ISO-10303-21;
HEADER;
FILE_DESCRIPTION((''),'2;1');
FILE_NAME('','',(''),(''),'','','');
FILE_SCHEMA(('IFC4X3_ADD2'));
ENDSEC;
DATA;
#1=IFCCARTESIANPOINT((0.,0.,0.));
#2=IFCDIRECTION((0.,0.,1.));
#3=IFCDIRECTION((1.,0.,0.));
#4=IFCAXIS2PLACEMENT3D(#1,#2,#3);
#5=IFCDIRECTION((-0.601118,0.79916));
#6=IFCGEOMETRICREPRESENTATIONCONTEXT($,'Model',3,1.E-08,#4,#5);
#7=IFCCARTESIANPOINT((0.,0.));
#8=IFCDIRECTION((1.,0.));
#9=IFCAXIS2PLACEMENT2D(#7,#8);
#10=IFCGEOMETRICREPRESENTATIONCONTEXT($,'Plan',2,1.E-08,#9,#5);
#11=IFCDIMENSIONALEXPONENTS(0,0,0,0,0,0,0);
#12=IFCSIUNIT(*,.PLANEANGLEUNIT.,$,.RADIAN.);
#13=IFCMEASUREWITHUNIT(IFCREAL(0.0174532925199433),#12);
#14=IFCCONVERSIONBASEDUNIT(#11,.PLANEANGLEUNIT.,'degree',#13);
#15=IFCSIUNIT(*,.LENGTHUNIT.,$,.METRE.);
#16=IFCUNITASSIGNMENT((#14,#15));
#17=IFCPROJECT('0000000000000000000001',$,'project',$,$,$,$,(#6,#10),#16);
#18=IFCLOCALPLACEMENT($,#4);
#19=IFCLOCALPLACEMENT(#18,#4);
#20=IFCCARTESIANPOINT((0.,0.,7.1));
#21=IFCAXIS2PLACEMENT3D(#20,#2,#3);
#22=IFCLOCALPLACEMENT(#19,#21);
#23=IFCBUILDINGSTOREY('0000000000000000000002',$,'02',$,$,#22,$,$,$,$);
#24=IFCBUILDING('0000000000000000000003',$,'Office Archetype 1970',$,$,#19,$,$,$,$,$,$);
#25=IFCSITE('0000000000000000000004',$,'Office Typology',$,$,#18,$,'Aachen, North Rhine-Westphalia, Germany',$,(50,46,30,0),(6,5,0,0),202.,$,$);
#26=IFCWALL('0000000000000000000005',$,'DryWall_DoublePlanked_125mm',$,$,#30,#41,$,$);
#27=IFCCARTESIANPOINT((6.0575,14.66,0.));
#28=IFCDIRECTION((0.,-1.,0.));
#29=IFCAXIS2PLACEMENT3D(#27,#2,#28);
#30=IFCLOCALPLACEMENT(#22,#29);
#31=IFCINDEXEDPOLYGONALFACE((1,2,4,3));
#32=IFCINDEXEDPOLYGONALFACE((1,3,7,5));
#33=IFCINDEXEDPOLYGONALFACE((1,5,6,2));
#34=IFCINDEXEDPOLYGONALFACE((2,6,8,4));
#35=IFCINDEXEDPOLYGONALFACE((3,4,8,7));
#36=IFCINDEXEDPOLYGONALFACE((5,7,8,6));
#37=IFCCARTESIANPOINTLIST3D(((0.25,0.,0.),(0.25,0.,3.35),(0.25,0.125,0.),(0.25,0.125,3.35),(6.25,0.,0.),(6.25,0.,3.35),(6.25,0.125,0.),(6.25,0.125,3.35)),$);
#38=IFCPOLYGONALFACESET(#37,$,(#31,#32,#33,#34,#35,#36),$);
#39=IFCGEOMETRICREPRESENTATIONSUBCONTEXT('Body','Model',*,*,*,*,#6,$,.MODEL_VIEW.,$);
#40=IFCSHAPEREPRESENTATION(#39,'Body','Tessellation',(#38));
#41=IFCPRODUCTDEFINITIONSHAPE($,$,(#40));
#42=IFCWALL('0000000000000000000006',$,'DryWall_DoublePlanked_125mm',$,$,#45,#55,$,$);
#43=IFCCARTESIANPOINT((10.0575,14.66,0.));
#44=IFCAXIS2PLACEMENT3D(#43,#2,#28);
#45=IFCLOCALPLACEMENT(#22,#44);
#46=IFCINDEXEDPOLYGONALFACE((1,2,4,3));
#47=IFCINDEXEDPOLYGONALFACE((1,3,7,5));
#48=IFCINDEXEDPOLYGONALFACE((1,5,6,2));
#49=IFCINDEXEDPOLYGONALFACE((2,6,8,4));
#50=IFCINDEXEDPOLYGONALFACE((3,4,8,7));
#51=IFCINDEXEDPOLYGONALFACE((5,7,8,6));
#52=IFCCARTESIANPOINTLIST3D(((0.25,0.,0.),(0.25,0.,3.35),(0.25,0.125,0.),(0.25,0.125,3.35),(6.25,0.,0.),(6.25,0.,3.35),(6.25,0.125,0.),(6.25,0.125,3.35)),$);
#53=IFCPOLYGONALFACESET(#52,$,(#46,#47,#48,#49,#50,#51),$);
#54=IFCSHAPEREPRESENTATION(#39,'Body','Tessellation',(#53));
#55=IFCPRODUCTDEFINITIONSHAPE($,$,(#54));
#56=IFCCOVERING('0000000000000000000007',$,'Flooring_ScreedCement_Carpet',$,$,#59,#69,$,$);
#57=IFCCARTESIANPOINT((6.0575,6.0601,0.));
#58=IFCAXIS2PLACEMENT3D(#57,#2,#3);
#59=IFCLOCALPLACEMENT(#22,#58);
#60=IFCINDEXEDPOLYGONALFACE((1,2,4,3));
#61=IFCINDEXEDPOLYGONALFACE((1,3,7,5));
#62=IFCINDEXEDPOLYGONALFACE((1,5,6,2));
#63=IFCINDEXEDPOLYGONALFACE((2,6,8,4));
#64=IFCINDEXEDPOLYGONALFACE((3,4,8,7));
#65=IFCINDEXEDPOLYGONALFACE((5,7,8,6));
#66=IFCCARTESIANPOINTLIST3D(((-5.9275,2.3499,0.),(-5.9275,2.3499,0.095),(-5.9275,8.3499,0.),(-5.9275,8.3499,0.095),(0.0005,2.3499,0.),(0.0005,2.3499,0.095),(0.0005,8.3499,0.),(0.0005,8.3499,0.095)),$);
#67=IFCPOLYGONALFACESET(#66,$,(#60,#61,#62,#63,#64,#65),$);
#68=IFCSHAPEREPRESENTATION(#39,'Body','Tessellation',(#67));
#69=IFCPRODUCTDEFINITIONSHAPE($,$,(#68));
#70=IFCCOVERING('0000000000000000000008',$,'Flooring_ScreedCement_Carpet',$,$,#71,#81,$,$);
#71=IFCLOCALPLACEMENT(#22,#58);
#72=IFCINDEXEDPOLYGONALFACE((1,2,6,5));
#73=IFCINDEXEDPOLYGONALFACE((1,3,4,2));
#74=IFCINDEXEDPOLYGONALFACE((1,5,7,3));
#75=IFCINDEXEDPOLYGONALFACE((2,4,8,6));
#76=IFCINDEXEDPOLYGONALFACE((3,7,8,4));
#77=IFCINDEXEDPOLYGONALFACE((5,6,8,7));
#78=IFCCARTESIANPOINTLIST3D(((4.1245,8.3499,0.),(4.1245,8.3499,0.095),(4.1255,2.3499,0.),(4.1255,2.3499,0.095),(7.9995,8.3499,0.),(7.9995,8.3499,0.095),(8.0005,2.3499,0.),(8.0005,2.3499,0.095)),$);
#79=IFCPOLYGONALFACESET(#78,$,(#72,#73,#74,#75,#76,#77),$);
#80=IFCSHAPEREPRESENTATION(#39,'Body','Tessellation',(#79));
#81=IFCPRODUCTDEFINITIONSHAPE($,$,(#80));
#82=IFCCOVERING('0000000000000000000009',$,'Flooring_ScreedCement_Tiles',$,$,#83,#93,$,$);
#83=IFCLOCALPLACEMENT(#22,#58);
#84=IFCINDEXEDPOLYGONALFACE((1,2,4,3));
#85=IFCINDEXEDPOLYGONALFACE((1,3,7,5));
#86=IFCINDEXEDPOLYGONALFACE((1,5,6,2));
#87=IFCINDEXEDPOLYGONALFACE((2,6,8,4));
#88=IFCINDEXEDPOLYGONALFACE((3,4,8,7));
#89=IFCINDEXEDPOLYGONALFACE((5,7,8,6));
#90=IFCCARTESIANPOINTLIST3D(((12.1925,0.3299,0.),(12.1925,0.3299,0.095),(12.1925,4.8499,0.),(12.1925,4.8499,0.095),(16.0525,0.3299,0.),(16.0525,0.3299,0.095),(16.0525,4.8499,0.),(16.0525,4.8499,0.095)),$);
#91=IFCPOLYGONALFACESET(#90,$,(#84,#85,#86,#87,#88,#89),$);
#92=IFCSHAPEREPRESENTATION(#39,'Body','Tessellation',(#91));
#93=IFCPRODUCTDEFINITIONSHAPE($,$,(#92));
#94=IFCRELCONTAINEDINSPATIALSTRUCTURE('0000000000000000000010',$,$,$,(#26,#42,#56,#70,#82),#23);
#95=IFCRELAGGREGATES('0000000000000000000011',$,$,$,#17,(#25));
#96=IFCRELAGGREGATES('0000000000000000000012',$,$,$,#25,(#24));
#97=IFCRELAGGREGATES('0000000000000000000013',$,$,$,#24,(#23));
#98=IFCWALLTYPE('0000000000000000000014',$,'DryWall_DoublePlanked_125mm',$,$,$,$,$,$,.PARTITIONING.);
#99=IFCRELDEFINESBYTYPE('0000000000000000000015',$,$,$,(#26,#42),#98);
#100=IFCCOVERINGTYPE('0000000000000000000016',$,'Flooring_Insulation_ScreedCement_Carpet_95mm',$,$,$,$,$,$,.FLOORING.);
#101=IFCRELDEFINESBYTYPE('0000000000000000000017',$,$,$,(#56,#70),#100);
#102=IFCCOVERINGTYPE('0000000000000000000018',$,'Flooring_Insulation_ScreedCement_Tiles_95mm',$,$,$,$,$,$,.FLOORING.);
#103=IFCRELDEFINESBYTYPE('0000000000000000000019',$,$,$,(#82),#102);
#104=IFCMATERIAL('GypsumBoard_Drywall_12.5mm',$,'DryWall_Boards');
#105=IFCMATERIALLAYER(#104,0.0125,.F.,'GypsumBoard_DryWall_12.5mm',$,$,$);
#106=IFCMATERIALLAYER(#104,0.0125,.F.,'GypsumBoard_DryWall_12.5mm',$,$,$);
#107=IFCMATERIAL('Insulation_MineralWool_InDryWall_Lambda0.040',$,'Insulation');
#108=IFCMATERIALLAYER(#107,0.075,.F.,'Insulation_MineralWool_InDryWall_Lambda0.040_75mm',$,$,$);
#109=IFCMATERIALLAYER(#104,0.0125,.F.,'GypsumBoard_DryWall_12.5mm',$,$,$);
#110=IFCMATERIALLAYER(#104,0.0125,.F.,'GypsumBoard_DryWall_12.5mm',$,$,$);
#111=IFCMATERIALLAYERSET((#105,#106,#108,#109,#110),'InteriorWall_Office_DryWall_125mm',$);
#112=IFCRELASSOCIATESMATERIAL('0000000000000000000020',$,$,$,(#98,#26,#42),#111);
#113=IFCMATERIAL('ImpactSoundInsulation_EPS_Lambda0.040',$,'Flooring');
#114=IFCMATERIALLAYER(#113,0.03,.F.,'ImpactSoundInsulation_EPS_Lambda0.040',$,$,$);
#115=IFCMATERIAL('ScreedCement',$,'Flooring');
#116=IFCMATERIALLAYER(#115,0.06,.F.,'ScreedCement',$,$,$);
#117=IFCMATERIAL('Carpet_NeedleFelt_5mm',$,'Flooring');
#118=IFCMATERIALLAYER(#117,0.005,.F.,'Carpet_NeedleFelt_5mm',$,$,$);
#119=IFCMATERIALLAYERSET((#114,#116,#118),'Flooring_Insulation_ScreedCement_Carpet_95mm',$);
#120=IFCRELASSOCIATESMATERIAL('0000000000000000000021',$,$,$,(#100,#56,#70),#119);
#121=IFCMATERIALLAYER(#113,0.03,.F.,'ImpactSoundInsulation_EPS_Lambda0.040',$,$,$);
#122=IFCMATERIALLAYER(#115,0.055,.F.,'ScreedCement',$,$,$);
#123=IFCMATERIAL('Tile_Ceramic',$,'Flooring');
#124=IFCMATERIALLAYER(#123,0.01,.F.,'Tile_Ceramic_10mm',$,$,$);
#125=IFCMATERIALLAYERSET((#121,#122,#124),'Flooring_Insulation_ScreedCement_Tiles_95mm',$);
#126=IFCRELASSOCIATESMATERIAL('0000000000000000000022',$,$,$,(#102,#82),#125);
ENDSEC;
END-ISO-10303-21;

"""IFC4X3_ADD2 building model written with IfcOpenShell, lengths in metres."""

from ifc_helpers import new_model, entity, si_unit, converted_unit, direction, frame, origin_with_axes, origin_2d_with_axis, place, context, subcontext, project, spatial, line, indexed_curve, outline, extrude, material, layer, layer_set, layer_usage, type_object, element, save


model = new_model("IFC4X3_ADD2")

# Units and contexts
model_context = context("Model", 3, precision=1e-08, world=origin_with_axes(), true_north=direction((-0.601118, 0.79916)))
plan_context = context("Plan", 2, precision=1e-08, world=origin_2d_with_axis(), true_north=direction((-0.601118, 0.79916)))
body_context = subcontext(model_context, "Body", "Model", "MODEL_VIEW")
ifc_project = project(units=[converted_unit("PLANEANGLEUNIT", "degree", entity("IfcReal", 0.0174532925199433), si_unit("PLANEANGLEUNIT", "RADIAN"), dimensions=[0, 0, 0, 0, 0, 0, 0]), si_unit("LENGTHUNIT", "METRE")], contexts=[model_context, plan_context])

# Site, building, storey
site_placement = place(None, origin_with_axes())
site = spatial("IfcSite", under=ifc_project, at=site_placement, Name="Office Typology", LongName="Aachen, North Rhine-Westphalia, Germany", RefLatitude=(50, 46, 30, 0), RefLongitude=(6, 5, 0, 0), RefElevation=202.0)
building_placement = place(site_placement, origin_with_axes())
building = spatial("IfcBuilding", under=site, at=building_placement, Name="Office Archetype 1970")
storey_placement = place(building_placement, frame((0.0, 0.0, 7.1), z_axis=(0.0, 0.0, 1.0), x_axis=(1.0, 0.0, 0.0)))
storey = spatial("IfcBuildingStorey", under=building, at=storey_placement, Name="02")

# Walls
ifc_material_1 = material(Name="GypsumBoard_Drywall_12.5mm", Category="DryWall_Boards")
ifc_layer_1 = layer(ifc_material_1, 0.0125, ventilated=False, Name="GypsumBoard_DryWall_12.5mm")
ifc_layer_2 = layer(ifc_material_1, 0.0125, ventilated=False, Name="GypsumBoard_DryWall_12.5mm")
ifc_material_2 = material(Name="Insulation_MineralWool_InDryWall_Lambda0.040", Category="Insulation")
ifc_layer_3 = layer(ifc_material_2, 0.075, ventilated=False, Name="Insulation_MineralWool_InDryWall_Lambda0.040_75mm")
ifc_layer_4 = layer(ifc_material_1, 0.0125, ventilated=False, Name="GypsumBoard_DryWall_12.5mm")
ifc_layer_5 = layer(ifc_material_1, 0.0125, ventilated=False, Name="GypsumBoard_DryWall_12.5mm")
ifc_layer_set_1 = layer_set([ifc_layer_1, ifc_layer_2, ifc_layer_3, ifc_layer_4, ifc_layer_5], Name="InteriorWall_Office_DryWall_125mm")
wall_type_1 = type_object("IfcWallType", Name="DryWall_DoublePlanked_125mm", PredefinedType="PARTITIONING", material=ifc_layer_set_1)
ifc_layer_usage_1 = layer_usage(ifc_layer_set_1, "AXIS2", "POSITIVE", 0.0)
wall_1_placement = place(storey_placement, frame((6.0575, 14.66, 0.0), z_axis=(0.0, 0.0, 1.0), x_axis=(0.0, -1.0, 0.0)))
element("IfcWall", 1, at=wall_1_placement, inside=storey, type_object=wall_type_1, material=ifc_layer_usage_1, Name="DryWall_DoublePlanked_125mm", context=body_context, shape_type="SweptSolid", body=[
    extrude(outline(indexed_curve([(0.25, 0.0), (0.25, 0.125), (6.25, 0.125), (6.25, 0.0)], segments=[line(1, 2, 3, 4, 1)])), origin_with_axes(), (0.0, 0.0, 1.0), 3.35),
])
ifc_layer_usage_2 = layer_usage(ifc_layer_set_1, "AXIS2", "POSITIVE", 0.0)
wall_2_placement = place(storey_placement, frame((10.0575, 14.66, 0.0), z_axis=(0.0, 0.0, 1.0), x_axis=(0.0, -1.0, 0.0)))
element("IfcWall", 2, at=wall_2_placement, inside=storey, type_object=wall_type_1, material=ifc_layer_usage_2, Name="DryWall_DoublePlanked_125mm", context=body_context, shape_type="SweptSolid", body=[
    extrude(outline(indexed_curve([(0.25, 0.0), (0.25, 0.125), (6.25, 0.125), (6.25, 0.0)], segments=[line(1, 2, 3, 4, 1)])), origin_with_axes(), (0.0, 0.0, 1.0), 3.35),
])

# Coverings
ifc_material_3 = material(Name="ImpactSoundInsulation_EPS_Lambda0.040", Category="Flooring")
ifc_layer_6 = layer(ifc_material_3, 0.03, ventilated=False, Name="ImpactSoundInsulation_EPS_Lambda0.040")
ifc_material_4 = material(Name="ScreedCement", Category="Flooring")
ifc_layer_7 = layer(ifc_material_4, 0.06, ventilated=False, Name="ScreedCement")
ifc_material_5 = material(Name="Carpet_NeedleFelt_5mm", Category="Flooring")
ifc_layer_8 = layer(ifc_material_5, 0.005, ventilated=False, Name="Carpet_NeedleFelt_5mm")
ifc_layer_set_2 = layer_set([ifc_layer_6, ifc_layer_7, ifc_layer_8], Name="Flooring_Insulation_ScreedCement_Carpet_95mm")
ifc_layer_usage_3 = layer_usage(ifc_layer_set_2, "AXIS3", "POSITIVE", 0.0)
covering_type_1 = type_object("IfcCoveringType", Name="Flooring_Insulation_ScreedCement_Carpet_95mm", PredefinedType="FLOORING", material=ifc_layer_set_2)
covering_1_placement = place(storey_placement, frame((6.0575, 6.0601, 0.0), z_axis=(0.0, 0.0, 1.0), x_axis=(1.0, 0.0, 0.0)))
element("IfcCovering", 3, at=covering_1_placement, inside=storey, type_object=covering_type_1, material=ifc_layer_usage_3, Name="Flooring_ScreedCement_Carpet", context=body_context, shape_type="SweptSolid", body=[
    extrude(outline(indexed_curve([(-5.9275, 2.3499), (-5.9275, 8.3499), (0.0005, 8.3499), (0.0005, 2.3499)], segments=[line(1, 2, 3, 4, 1)])), origin_with_axes(), (0.0, 0.0, 1.0), 0.095),
])
ifc_layer_usage_4 = layer_usage(ifc_layer_set_2, "AXIS3", "POSITIVE", 0.0)
covering_2_placement = place(storey_placement, frame((6.0575, 6.0601, 0.0), z_axis=(0.0, 0.0, 1.0), x_axis=(1.0, 0.0, 0.0)))
element("IfcCovering", 4, at=covering_2_placement, inside=storey, type_object=covering_type_1, material=ifc_layer_usage_4, Name="Flooring_ScreedCement_Carpet", context=body_context, shape_type="SweptSolid", body=[
    extrude(outline(indexed_curve([(4.1255, 2.3499), (4.1245, 8.3499), (7.9995, 8.3499), (8.0005, 2.3499)], segments=[line(1, 2, 3, 4, 1)])), origin_with_axes(), (0.0, 0.0, 1.0), 0.095),
])
ifc_layer_9 = layer(ifc_material_3, 0.03, ventilated=False, Name="ImpactSoundInsulation_EPS_Lambda0.040")
ifc_layer_10 = layer(ifc_material_4, 0.055, ventilated=False, Name="ScreedCement")
ifc_material_6 = material(Name="Tile_Ceramic", Category="Flooring")
ifc_layer_11 = layer(ifc_material_6, 0.01, ventilated=False, Name="Tile_Ceramic_10mm")
ifc_layer_set_3 = layer_set([ifc_layer_9, ifc_layer_10, ifc_layer_11], Name="Flooring_Insulation_ScreedCement_Tiles_95mm")
ifc_layer_usage_5 = layer_usage(ifc_layer_set_3, "AXIS3", "POSITIVE", 0.0)
covering_type_2 = type_object("IfcCoveringType", Name="Flooring_Insulation_ScreedCement_Tiles_95mm", PredefinedType="FLOORING", material=ifc_layer_set_3)
covering_3_placement = place(storey_placement, frame((6.0575, 6.0601, 0.0), z_axis=(0.0, 0.0, 1.0), x_axis=(1.0, 0.0, 0.0)))
element("IfcCovering", 5, at=covering_3_placement, inside=storey, type_object=covering_type_2, material=ifc_layer_usage_5, Name="Flooring_ScreedCement_Tiles", context=body_context, shape_type="SweptSolid", body=[
    extrude(outline(indexed_curve([(12.1925, 0.3299), (12.1925, 4.8499), (16.0525, 4.8499), (16.0525, 0.3299)], segments=[line(1, 2, 3, 4, 1)])), origin_with_axes(), (0.0, 0.0, 1.0), 0.095),
])

save(model, "model.ifc")
